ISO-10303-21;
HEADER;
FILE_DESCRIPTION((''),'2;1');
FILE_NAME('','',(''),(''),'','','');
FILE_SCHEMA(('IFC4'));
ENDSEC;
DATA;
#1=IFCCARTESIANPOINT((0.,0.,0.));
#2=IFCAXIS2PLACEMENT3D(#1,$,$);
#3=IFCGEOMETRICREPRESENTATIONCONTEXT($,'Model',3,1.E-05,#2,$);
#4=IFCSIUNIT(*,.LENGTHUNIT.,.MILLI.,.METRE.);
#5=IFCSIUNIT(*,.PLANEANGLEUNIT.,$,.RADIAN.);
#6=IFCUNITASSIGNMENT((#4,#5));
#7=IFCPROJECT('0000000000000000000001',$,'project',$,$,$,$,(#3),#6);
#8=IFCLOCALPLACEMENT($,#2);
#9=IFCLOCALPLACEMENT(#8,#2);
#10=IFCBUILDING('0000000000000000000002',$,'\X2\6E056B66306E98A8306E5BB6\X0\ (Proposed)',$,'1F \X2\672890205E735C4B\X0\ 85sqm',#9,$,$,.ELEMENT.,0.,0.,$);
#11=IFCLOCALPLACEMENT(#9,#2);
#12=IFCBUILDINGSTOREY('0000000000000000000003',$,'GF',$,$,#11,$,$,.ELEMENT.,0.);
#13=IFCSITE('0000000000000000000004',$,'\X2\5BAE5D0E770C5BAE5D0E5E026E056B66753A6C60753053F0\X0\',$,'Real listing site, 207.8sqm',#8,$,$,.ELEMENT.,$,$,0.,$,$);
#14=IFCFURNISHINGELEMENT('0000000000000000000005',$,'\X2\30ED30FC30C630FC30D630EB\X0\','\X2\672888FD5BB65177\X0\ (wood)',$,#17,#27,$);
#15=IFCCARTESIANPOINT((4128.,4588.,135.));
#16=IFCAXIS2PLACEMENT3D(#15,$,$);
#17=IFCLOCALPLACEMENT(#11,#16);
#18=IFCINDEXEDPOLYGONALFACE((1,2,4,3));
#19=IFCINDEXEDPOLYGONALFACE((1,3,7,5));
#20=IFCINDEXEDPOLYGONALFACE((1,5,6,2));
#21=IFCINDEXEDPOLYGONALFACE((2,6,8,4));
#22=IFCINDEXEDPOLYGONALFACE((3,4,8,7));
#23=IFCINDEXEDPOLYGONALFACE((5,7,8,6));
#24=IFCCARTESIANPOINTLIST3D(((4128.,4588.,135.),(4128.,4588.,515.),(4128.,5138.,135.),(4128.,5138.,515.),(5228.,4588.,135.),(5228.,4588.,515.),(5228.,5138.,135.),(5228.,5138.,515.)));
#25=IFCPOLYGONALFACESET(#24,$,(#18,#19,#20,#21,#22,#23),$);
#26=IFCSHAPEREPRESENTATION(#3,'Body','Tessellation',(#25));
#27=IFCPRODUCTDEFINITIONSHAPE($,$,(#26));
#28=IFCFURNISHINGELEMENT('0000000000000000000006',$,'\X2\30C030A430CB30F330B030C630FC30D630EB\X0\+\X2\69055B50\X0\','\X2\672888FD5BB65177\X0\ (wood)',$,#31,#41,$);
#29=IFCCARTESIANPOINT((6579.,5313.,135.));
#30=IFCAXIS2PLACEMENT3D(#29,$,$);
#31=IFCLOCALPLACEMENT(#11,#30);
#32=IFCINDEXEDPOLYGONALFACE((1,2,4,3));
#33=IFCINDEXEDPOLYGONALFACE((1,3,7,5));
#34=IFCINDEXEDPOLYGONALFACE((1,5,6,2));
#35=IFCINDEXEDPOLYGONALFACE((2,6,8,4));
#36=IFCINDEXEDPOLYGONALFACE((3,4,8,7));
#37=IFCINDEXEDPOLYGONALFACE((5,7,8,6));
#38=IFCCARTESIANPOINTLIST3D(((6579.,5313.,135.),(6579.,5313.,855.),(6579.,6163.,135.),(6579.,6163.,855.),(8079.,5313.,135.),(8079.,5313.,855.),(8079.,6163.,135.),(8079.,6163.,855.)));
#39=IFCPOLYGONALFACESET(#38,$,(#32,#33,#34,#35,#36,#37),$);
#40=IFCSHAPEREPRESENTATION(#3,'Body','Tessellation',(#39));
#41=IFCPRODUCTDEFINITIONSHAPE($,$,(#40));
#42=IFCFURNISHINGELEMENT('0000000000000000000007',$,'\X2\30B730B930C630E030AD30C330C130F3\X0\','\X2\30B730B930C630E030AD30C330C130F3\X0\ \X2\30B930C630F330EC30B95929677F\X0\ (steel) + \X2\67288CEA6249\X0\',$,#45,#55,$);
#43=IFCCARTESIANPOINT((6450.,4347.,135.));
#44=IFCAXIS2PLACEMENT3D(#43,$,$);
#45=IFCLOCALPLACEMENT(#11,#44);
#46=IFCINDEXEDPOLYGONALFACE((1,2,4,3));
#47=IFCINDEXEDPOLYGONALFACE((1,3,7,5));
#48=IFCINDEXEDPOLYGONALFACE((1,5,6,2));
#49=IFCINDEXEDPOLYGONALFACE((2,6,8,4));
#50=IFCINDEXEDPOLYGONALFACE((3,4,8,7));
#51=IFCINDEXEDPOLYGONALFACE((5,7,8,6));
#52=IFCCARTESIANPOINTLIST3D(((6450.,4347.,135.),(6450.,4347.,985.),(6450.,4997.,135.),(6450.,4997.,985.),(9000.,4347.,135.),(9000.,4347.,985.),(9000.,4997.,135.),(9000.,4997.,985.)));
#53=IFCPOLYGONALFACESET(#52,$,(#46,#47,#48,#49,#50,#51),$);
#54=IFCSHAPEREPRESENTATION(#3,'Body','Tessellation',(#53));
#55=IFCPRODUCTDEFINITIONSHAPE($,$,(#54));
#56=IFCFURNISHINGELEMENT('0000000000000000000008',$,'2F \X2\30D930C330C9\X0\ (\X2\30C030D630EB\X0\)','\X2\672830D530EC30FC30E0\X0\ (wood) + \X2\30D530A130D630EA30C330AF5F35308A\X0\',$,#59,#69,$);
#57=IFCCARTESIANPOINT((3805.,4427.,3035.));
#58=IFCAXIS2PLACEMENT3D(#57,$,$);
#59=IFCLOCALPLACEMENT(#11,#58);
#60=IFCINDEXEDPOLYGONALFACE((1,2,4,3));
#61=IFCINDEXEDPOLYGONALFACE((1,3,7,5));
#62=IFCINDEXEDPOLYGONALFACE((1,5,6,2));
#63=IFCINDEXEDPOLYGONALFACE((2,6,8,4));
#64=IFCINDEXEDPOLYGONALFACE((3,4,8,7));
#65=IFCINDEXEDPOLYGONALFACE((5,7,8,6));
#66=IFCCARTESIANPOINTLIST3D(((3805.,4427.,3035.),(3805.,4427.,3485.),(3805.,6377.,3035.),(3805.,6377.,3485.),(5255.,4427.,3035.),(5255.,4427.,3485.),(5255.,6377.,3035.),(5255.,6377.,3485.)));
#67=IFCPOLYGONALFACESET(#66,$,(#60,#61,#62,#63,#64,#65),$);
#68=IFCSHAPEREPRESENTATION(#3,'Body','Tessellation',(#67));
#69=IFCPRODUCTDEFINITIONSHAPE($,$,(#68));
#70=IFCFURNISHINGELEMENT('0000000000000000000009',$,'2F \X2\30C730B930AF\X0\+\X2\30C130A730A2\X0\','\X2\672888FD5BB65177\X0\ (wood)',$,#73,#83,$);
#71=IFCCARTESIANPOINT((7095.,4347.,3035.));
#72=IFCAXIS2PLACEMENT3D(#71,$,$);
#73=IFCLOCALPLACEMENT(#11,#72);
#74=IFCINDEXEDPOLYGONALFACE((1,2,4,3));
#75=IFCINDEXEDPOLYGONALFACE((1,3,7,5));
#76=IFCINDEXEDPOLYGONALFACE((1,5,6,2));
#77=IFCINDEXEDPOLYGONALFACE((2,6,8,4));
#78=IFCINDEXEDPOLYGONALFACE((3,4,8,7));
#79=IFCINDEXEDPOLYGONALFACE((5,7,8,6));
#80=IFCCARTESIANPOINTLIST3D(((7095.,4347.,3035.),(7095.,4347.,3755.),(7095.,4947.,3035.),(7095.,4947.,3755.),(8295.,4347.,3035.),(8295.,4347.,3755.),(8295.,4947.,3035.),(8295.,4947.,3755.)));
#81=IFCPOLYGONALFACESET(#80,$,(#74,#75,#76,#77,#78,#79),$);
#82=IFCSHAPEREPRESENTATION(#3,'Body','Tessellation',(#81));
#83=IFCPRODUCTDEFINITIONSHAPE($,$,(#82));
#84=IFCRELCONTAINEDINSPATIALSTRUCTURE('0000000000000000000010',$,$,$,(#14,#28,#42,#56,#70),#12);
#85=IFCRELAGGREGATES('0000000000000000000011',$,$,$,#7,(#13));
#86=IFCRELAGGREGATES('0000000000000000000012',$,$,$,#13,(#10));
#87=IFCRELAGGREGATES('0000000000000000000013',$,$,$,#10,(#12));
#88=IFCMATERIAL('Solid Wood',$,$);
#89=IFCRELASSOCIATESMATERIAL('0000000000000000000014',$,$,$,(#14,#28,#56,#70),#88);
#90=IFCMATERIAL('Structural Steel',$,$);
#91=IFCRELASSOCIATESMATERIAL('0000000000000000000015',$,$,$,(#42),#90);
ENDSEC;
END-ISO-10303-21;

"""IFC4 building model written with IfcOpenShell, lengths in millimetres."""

from ifc_helpers import new_model, si_unit, frame, frame_2d, origin, place, context, project, spatial, rectangle, extrude, material, element, save


model = new_model("IFC4")

# Units and contexts
model_context = context("Model", 3, precision=1e-05, world=origin())
ifc_project = project(units=[si_unit("LENGTHUNIT", "METRE", prefix="MILLI"), si_unit("PLANEANGLEUNIT", "RADIAN")], contexts=[model_context])

# Site, building, storey
site_placement = place(None, origin())
site = spatial("IfcSite", under=ifc_project, at=site_placement, Name="宮崎県宮崎市清武町池田台", ObjectType="Real listing site, 207.8sqm", CompositionType="ELEMENT", RefElevation=0.0)
building_placement = place(site_placement, origin())
building = spatial("IfcBuilding", under=site, at=building_placement, Name="清武の風の家 (Proposed)", ObjectType="1F 木造平屋 85sqm", CompositionType="ELEMENT", ElevationOfRefHeight=0.0, ElevationOfTerrain=0.0)
storey_placement = place(building_placement, origin())
storey = spatial("IfcBuildingStorey", under=building, at=storey_placement, Name="GF", CompositionType="ELEMENT", Elevation=0.0)

# Shared definitions
ifc_material_1 = material(Name="Solid Wood")

# Shared definitions
ifc_material_2 = material(Name="Structural Steel")

# Furnishing elements
furnishing_1_placement = place(storey_placement, frame((4128.0, 4588.0, 135.0)))
element("IfcFurnishingElement", 1, at=furnishing_1_placement, inside=storey, material=ifc_material_1, Name="ローテーブル", Description="木製家具 (wood)", context=model_context, shape_type="SweptSolid", body=[
    extrude(rectangle(XDim=1100.0, YDim=550.0, at=frame_2d((550.0, 275.0))), frame((4128.0, 4588.0, 135.0)), (0.0, 0.0, 1.0), 380.0),
])
furnishing_2_placement = place(storey_placement, frame((6579.0, 5313.0, 135.0)))
element("IfcFurnishingElement", 2, at=furnishing_2_placement, inside=storey, material=ifc_material_1, Name="ダイニングテーブル+椅子", Description="木製家具 (wood)", context=model_context, shape_type="SweptSolid", body=[
    extrude(rectangle(XDim=1500.0, YDim=850.0, at=frame_2d((750.0, 425.0))), frame((6579.0, 5313.0, 135.0)), (0.0, 0.0, 1.0), 720.0),
])
furnishing_3_placement = place(storey_placement, frame((6450.0, 4347.0, 135.0)))
element("IfcFurnishingElement", 3, at=furnishing_3_placement, inside=storey, material=ifc_material_2, Name="システムキッチン", Description="システムキッチン ステンレス天板 (steel) + 木質扉", context=model_context, shape_type="SweptSolid", body=[
    extrude(rectangle(XDim=2550.0, YDim=650.0, at=frame_2d((1275.0, 325.0))), frame((6450.0, 4347.0, 135.0)), (0.0, 0.0, 1.0), 850.0),
])
furnishing_4_placement = place(storey_placement, frame((3805.0, 4427.0, 3035.0)))
element("IfcFurnishingElement", 4, at=furnishing_4_placement, inside=storey, material=ifc_material_1, Name="2F ベッド (ダブル)", Description="木フレーム (wood) + ファブリック張り", context=model_context, shape_type="SweptSolid", body=[
    extrude(rectangle(XDim=1450.0, YDim=1950.0, at=frame_2d((725.0, 975.0))), frame((3805.0, 4427.0, 3035.0)), (0.0, 0.0, 1.0), 450.0),
])
furnishing_5_placement = place(storey_placement, frame((7095.0, 4347.0, 3035.0)))
element("IfcFurnishingElement", 5, at=furnishing_5_placement, inside=storey, material=ifc_material_1, Name="2F デスク+チェア", Description="木製家具 (wood)", context=model_context, shape_type="SweptSolid", body=[
    extrude(rectangle(XDim=1200.0, YDim=600.0, at=frame_2d((600.0, 300.0))), frame((7095.0, 4347.0, 3035.0)), (0.0, 0.0, 1.0), 720.0),
])

save(model, "model.ifc")
